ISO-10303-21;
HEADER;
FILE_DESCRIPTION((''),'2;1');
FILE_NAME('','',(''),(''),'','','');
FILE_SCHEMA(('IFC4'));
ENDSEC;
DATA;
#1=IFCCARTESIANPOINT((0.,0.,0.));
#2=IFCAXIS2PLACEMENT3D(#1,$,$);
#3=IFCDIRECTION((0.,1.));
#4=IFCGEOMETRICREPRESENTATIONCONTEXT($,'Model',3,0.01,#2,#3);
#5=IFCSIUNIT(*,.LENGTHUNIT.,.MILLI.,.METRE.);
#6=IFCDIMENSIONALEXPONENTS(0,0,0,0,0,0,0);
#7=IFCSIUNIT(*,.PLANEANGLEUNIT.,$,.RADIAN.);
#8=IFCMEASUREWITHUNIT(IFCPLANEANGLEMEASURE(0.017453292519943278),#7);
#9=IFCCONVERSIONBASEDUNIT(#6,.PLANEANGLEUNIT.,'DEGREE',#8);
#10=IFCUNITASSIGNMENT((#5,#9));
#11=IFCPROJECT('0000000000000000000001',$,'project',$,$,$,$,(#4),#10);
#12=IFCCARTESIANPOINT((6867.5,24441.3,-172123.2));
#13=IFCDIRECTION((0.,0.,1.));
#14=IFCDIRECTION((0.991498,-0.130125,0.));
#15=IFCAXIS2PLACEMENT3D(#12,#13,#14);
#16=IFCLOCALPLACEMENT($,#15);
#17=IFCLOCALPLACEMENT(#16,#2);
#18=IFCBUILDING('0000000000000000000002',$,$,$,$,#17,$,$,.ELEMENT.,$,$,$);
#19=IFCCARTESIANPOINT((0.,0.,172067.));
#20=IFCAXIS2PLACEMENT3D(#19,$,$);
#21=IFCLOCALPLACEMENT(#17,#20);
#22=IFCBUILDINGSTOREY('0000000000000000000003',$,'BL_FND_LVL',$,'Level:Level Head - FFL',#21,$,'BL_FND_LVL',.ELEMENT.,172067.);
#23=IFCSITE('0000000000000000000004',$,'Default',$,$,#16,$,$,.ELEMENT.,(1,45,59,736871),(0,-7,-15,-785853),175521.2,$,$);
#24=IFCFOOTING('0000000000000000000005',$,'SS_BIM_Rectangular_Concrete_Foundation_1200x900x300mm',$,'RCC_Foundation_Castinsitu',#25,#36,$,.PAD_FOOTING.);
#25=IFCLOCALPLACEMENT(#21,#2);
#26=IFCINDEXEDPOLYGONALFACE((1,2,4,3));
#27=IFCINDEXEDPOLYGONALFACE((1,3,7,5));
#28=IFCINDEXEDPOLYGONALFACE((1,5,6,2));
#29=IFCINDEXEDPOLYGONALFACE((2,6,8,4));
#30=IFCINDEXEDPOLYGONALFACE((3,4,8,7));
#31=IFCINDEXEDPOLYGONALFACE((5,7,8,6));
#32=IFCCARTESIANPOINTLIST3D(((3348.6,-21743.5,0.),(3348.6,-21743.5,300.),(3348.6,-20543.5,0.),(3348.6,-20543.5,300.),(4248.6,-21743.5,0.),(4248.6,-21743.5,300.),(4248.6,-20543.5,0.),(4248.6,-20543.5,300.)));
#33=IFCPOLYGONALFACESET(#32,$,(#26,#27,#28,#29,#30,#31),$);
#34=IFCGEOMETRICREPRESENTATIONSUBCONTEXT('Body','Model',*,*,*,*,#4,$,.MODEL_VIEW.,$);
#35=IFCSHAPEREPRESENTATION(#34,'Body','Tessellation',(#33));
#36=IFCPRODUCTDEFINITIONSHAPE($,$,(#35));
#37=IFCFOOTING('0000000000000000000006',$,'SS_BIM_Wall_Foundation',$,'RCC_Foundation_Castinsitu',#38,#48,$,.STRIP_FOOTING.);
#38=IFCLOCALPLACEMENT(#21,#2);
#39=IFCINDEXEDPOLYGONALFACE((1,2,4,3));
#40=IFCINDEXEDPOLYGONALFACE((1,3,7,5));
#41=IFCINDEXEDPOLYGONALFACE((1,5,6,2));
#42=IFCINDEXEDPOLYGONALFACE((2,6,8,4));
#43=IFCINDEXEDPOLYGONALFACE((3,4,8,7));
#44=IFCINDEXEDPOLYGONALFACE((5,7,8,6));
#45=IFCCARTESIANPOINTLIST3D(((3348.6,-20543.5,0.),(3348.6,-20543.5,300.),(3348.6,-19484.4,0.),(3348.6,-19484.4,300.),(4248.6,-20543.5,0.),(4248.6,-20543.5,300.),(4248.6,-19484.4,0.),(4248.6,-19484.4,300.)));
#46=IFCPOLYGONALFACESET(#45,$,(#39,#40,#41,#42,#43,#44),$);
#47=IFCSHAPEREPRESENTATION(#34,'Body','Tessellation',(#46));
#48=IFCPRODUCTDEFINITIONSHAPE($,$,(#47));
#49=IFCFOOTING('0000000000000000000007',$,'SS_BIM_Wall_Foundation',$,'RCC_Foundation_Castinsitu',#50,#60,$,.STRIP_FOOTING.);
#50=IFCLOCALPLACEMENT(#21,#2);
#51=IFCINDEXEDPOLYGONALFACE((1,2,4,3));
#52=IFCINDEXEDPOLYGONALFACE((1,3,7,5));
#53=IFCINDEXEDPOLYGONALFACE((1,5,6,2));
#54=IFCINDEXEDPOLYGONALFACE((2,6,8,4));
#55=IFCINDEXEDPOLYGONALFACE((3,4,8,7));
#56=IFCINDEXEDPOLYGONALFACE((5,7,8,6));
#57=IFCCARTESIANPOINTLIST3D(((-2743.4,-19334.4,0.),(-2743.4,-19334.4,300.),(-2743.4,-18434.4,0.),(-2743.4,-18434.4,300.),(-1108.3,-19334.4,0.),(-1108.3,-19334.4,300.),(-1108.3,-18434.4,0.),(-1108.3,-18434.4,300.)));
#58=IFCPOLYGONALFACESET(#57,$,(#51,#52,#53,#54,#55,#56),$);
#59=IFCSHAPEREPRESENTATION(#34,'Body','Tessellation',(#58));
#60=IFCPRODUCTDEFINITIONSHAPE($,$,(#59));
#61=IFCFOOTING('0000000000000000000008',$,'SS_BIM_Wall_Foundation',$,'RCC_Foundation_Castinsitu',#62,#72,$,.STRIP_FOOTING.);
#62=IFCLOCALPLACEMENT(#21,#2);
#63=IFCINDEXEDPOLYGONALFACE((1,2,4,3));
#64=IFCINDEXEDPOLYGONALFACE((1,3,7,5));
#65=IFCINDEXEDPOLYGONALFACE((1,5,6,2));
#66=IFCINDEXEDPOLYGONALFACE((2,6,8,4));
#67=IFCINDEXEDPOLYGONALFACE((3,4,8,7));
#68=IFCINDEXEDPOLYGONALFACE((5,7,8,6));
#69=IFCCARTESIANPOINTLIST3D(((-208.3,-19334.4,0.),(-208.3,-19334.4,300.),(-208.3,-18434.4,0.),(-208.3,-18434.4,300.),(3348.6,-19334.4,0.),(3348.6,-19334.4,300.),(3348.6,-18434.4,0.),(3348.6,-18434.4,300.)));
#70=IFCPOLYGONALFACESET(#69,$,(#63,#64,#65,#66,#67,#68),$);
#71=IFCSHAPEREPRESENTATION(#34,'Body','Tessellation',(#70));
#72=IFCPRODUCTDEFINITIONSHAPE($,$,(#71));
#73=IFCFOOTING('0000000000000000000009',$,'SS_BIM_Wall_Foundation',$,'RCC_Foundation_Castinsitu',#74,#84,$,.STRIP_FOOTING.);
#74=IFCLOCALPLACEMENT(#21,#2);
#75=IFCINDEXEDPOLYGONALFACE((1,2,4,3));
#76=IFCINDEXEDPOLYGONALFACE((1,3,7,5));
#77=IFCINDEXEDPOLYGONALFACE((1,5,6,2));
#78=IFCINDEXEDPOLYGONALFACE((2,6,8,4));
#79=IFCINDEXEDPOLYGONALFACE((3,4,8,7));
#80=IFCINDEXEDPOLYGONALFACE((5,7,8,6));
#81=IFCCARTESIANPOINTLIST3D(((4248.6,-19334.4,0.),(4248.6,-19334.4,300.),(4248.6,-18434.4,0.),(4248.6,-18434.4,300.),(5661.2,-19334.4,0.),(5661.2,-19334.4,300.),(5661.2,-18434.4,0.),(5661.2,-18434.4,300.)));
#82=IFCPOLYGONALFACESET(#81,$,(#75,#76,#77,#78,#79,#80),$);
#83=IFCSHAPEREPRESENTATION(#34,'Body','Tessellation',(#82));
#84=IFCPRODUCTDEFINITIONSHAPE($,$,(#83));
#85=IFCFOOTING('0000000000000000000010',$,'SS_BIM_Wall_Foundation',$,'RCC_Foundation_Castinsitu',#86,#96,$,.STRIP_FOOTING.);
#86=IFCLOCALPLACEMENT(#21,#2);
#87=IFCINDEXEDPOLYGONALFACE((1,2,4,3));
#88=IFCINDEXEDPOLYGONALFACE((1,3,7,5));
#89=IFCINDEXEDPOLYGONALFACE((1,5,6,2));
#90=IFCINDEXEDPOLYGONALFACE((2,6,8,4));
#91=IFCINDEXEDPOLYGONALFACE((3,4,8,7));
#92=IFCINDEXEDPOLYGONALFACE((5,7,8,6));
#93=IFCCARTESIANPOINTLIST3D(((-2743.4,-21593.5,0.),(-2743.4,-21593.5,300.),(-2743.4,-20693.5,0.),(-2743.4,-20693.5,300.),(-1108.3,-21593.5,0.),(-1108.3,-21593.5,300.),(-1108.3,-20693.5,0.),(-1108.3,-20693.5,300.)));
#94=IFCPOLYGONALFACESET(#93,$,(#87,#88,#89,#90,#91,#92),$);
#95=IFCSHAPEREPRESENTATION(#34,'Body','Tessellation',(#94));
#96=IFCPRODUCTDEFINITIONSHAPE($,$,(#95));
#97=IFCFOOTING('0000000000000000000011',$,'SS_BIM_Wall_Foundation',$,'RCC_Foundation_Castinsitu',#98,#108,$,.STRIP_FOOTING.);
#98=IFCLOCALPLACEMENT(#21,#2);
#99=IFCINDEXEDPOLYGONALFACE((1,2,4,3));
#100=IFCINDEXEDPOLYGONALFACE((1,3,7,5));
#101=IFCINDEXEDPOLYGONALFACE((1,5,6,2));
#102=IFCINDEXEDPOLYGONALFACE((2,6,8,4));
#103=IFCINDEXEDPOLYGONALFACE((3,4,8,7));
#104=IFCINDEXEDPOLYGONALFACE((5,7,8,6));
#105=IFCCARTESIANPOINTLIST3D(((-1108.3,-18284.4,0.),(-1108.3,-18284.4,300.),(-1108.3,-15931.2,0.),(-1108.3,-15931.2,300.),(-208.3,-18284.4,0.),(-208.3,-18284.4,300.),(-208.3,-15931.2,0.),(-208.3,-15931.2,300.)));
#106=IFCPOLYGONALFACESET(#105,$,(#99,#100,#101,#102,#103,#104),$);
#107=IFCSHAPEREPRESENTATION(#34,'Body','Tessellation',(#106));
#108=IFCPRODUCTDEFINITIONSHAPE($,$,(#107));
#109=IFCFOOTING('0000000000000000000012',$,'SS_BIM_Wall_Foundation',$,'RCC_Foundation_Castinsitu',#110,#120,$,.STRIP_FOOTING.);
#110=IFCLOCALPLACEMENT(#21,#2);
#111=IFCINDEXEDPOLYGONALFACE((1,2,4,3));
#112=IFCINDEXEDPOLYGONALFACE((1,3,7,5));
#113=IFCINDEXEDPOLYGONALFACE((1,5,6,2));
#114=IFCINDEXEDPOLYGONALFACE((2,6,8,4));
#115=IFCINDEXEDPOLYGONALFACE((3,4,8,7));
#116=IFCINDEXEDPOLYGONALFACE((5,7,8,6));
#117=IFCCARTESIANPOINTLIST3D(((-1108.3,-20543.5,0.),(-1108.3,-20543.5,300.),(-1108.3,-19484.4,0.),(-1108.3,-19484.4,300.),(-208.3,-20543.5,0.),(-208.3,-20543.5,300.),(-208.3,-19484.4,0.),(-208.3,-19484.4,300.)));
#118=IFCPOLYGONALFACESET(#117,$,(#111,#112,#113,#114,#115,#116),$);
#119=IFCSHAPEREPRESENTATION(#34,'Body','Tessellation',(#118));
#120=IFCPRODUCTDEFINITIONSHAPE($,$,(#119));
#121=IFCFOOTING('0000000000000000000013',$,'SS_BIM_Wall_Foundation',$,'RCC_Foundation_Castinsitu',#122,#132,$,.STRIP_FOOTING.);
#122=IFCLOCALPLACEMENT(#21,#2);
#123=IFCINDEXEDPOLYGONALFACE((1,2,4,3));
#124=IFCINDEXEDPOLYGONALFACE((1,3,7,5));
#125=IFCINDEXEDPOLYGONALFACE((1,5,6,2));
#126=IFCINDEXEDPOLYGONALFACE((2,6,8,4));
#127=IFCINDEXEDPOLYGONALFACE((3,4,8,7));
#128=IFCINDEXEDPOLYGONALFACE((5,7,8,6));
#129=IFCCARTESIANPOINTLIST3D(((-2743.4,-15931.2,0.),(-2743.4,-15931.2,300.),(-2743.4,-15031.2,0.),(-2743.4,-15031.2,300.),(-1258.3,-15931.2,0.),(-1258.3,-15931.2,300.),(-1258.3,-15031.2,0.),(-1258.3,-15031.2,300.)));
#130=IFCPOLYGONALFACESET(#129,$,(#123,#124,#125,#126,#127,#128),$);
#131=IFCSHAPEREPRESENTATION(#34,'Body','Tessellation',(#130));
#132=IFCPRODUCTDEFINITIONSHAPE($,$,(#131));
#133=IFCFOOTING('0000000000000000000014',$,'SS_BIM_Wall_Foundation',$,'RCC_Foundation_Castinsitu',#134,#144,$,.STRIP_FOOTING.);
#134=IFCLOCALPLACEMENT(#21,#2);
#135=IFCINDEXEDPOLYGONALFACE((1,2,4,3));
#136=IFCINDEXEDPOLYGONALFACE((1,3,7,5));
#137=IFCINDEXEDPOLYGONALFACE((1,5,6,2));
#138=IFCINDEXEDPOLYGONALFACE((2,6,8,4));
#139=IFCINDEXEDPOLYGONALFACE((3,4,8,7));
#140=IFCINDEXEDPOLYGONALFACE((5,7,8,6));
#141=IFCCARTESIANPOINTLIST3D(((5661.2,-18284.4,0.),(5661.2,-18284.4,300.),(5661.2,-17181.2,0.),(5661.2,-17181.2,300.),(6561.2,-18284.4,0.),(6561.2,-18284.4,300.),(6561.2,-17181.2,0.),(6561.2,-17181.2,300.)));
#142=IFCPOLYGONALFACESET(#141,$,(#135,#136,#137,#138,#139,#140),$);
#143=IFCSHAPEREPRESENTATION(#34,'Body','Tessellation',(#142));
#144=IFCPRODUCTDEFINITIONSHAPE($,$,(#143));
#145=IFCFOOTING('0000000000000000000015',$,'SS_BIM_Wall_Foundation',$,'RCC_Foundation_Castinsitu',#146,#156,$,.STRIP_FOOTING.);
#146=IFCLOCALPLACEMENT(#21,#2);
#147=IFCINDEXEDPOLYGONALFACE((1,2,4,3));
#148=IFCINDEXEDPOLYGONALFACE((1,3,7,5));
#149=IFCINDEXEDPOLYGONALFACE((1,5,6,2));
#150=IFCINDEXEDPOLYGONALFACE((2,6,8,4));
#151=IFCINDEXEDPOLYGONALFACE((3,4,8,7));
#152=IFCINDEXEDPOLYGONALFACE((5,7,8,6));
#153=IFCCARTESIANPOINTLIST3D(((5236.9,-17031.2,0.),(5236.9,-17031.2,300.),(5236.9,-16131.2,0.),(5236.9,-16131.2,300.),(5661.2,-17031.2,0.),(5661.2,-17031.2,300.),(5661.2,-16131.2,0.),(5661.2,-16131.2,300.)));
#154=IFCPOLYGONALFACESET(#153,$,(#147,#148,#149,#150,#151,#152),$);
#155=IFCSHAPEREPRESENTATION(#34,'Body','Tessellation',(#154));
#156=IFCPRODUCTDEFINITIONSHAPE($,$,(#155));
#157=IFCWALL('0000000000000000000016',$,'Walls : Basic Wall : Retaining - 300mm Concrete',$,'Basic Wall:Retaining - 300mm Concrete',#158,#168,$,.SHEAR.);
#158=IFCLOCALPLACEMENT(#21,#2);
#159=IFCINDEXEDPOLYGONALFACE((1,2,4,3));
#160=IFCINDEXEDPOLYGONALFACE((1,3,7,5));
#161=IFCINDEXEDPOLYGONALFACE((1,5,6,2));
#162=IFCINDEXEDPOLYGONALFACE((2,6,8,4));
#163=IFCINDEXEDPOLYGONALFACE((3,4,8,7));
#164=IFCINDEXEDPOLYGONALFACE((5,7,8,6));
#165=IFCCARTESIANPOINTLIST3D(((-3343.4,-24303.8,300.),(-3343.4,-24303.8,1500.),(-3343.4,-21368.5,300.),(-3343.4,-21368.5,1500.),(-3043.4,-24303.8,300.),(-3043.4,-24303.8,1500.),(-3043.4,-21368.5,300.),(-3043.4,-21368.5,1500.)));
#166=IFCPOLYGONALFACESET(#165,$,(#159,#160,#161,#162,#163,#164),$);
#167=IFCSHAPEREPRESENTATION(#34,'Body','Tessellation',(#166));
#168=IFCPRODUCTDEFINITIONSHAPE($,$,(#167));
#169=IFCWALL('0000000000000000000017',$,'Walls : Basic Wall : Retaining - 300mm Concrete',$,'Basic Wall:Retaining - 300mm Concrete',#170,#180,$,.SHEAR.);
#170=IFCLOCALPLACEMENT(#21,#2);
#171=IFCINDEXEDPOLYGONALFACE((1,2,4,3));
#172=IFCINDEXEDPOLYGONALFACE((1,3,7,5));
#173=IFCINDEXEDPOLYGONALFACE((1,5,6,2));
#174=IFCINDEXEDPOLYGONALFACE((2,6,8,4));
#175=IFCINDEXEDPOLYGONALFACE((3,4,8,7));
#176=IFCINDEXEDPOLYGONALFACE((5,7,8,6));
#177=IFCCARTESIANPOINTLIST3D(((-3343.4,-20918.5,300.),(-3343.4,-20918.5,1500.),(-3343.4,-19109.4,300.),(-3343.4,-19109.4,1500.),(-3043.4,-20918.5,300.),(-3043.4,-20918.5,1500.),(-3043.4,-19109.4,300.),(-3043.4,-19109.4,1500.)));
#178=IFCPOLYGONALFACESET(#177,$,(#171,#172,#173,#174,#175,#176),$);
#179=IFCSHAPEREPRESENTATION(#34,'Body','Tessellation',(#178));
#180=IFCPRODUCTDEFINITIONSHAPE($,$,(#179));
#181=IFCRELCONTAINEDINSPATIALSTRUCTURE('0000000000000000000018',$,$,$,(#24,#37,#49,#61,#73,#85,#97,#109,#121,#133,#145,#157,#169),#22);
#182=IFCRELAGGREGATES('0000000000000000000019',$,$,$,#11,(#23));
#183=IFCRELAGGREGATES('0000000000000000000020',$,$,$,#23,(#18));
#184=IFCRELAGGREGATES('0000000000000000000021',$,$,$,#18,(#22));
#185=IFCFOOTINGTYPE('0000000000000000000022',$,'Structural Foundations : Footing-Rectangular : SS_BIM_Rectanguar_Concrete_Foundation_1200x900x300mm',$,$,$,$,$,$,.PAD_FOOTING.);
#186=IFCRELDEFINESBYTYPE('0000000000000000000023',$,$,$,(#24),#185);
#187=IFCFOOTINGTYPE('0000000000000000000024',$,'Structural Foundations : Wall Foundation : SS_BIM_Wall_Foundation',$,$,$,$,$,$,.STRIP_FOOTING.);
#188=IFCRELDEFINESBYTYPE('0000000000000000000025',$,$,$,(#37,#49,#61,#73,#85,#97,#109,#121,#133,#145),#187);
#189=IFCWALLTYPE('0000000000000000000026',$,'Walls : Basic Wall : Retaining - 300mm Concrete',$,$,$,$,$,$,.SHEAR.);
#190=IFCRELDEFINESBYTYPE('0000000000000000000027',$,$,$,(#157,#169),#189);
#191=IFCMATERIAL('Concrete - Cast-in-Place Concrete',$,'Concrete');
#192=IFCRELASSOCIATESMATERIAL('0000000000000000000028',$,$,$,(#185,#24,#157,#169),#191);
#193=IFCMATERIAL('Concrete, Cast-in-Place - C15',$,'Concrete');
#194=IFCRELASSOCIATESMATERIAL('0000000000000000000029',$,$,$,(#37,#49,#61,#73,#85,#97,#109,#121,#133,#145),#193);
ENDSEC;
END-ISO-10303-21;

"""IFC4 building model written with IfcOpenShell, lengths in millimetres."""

from ifc_helpers import new_model, entity, si_unit, converted_unit, direction, frame, origin, place, context, subcontext, project, spatial, indexed_curve, outline, extrude, source, transform, mapped, material, type_object, type_shapes, element, save


model = new_model("IFC4")

# Units and contexts
model_context = context("Model", 3, precision=0.01, world=origin(), true_north=direction((0.0, 1.0)))
body_context = subcontext(model_context, "Body", "Model", "MODEL_VIEW")
ifc_project = project(units=[si_unit("LENGTHUNIT", "METRE", prefix="MILLI"), converted_unit("PLANEANGLEUNIT", "DEGREE", entity("IfcPlaneAngleMeasure", 0.017453292519943278), si_unit("PLANEANGLEUNIT", "RADIAN"), dimensions=[0, 0, 0, 0, 0, 0, 0])], contexts=[model_context])

# Site, building, storey
site_placement = place(None, frame((6867.5, 24441.3, -172123.2), z_axis=(0.0, 0.0, 1.0), x_axis=(0.991498, -0.130125, 0.0)))
site = spatial("IfcSite", under=ifc_project, at=site_placement, Name="Default", CompositionType="ELEMENT", RefLatitude=(1, 45, 59, 736871), RefLongitude=(0, -7, -15, -785853), RefElevation=175521.2)
building_placement = place(site_placement, origin())
building = spatial("IfcBuilding", under=site, at=building_placement, CompositionType="ELEMENT")
storey_placement = place(building_placement, frame((0.0, 0.0, 172067.0)))
storey = spatial("IfcBuildingStorey", under=building, at=storey_placement, Name="BL_FND_LVL", ObjectType="Level:Level Head - FFL", LongName="BL_FND_LVL", CompositionType="ELEMENT", Elevation=172067.0)

# Footings
ifc_material_1 = material(Name="Concrete - Cast-in-Place Concrete", Category="Concrete")
footing_type_1 = type_object("IfcFootingType", Name="Structural Foundations : Footing-Rectangular : SS_BIM_Rectanguar_Concrete_Foundation_1200x900x300mm", PredefinedType="PAD_FOOTING", material=ifc_material_1)
shared_shape = source(origin(), body_context, "Body", "SweptSolid", [
    extrude(outline(indexed_curve([(-450.0, -600.0), (450.0, -600.0), (450.0, 600.0), (-450.0, 600.0), (-450.0, -600.0)], self_intersect=False)), frame((0.0, 0.0, -300.0), z_axis=(0.0, 0.0, 1.0), x_axis=(-1.0, 0.0, 0.0)), (0.0, 0.0, 1.0), 300.0),
])
type_shapes(footing_type_1, [shared_shape])
footing_1_placement = place(storey_placement, frame((3798.6, -21143.5, 300.0)))
element("IfcFooting", 1, at=footing_1_placement, inside=storey, type_object=footing_type_1, material=ifc_material_1, Name="SS_BIM_Rectangular_Concrete_Foundation_1200x900x300mm", ObjectType="RCC_Foundation_Castinsitu", PredefinedType="PAD_FOOTING", context=body_context, shape_type="MappedRepresentation", body=[
    mapped(shared_shape, transform((0.0, 0.0, 0.0), scale=1.0)),
])
ifc_material_2 = material(Name="Concrete, Cast-in-Place - C15", Category="Concrete")
footing_type_2 = type_object("IfcFootingType", Name="Structural Foundations : Wall Foundation : SS_BIM_Wall_Foundation", PredefinedType="STRIP_FOOTING")
footing_2_placement = place(storey_placement, origin())
element("IfcFooting", 2, at=footing_2_placement, inside=storey, type_object=footing_type_2, material=ifc_material_2, Name="SS_BIM_Wall_Foundation", ObjectType="RCC_Foundation_Castinsitu", PredefinedType="STRIP_FOOTING", context=body_context, shape_type="SweptSolid", body=[
    extrude(outline(indexed_curve([(-529.6, -450.0), (529.6, -450.0), (529.6, 450.0), (-529.6, 450.0), (-529.6, -450.0)], self_intersect=False)), frame((3798.6, -20013.9, 0.0), z_axis=(0.0, 0.0, 1.0), x_axis=(0.0, -1.0, 0.0)), (0.0, 0.0, 1.0), 300.0),
])
footing_3_placement = place(storey_placement, origin())
element("IfcFooting", 3, at=footing_3_placement, inside=storey, type_object=footing_type_2, material=ifc_material_2, Name="SS_BIM_Wall_Foundation", ObjectType="RCC_Foundation_Castinsitu", PredefinedType="STRIP_FOOTING", context=body_context, shape_type="SweptSolid", body=[
    extrude(outline(indexed_curve([(-817.5, -450.0), (817.5, -450.0), (817.5, 450.0), (-817.5, 450.0), (-817.5, -450.0)], self_intersect=False)), frame((-1925.8, -18884.4, 0.0)), (0.0, 0.0, 1.0), 300.0),
])
footing_4_placement = place(storey_placement, origin())
element("IfcFooting", 4, at=footing_4_placement, inside=storey, type_object=footing_type_2, material=ifc_material_2, Name="SS_BIM_Wall_Foundation", ObjectType="RCC_Foundation_Castinsitu", PredefinedType="STRIP_FOOTING", context=body_context, shape_type="SweptSolid", body=[
    extrude(outline(indexed_curve([(-1778.5, -450.0), (1778.5, -450.0), (1778.5, 450.0), (-1778.5, 450.0), (-1778.5, -450.0)], self_intersect=False)), frame((1570.2, -18884.4, 0.0)), (0.0, 0.0, 1.0), 300.0),
])
footing_5_placement = place(storey_placement, origin())
element("IfcFooting", 5, at=footing_5_placement, inside=storey, type_object=footing_type_2, material=ifc_material_2, Name="SS_BIM_Wall_Foundation", ObjectType="RCC_Foundation_Castinsitu", PredefinedType="STRIP_FOOTING", context=body_context, shape_type="SweptSolid", body=[
    extrude(outline(indexed_curve([(-706.3, -450.0), (706.3, -450.0), (706.3, 450.0), (-706.3, 450.0), (-706.3, -450.0)], self_intersect=False)), frame((4954.9, -18884.4, 0.0)), (0.0, 0.0, 1.0), 300.0),
])
footing_6_placement = place(storey_placement, origin())
element("IfcFooting", 6, at=footing_6_placement, inside=storey, type_object=footing_type_2, material=ifc_material_2, Name="SS_BIM_Wall_Foundation", ObjectType="RCC_Foundation_Castinsitu", PredefinedType="STRIP_FOOTING", context=body_context, shape_type="SweptSolid", body=[
    extrude(outline(indexed_curve([(-817.5, -450.0), (817.5, -450.0), (817.5, 450.0), (-817.5, 450.0), (-817.5, -450.0)], self_intersect=False)), frame((-1925.8, -21143.5, 0.0)), (0.0, 0.0, 1.0), 300.0),
])
footing_7_placement = place(storey_placement, origin())
element("IfcFooting", 7, at=footing_7_placement, inside=storey, type_object=footing_type_2, material=ifc_material_2, Name="SS_BIM_Wall_Foundation", ObjectType="RCC_Foundation_Castinsitu", PredefinedType="STRIP_FOOTING", context=body_context, shape_type="SweptSolid", body=[
    extrude(outline(indexed_curve([(-1176.6, -450.0), (1176.6, -450.0), (1176.6, 450.0), (-1176.6, 450.0), (-1176.6, -450.0)], self_intersect=False)), frame((-658.3, -17107.8, 0.0), z_axis=(0.0, 0.0, 1.0), x_axis=(0.0, -1.0, 0.0)), (0.0, 0.0, 1.0), 300.0),
])
footing_8_placement = place(storey_placement, origin())
element("IfcFooting", 8, at=footing_8_placement, inside=storey, type_object=footing_type_2, material=ifc_material_2, Name="SS_BIM_Wall_Foundation", ObjectType="RCC_Foundation_Castinsitu", PredefinedType="STRIP_FOOTING", context=body_context, shape_type="SweptSolid", body=[
    extrude(outline(indexed_curve([(-529.6, -450.0), (529.6, -450.0), (529.6, 450.0), (-529.6, 450.0), (-529.6, -450.0)], self_intersect=False)), frame((-658.3, -20013.9, 0.0), z_axis=(0.0, 0.0, 1.0), x_axis=(0.0, -1.0, 0.0)), (0.0, 0.0, 1.0), 300.0),
])
footing_9_placement = place(storey_placement, origin())
element("IfcFooting", 9, at=footing_9_placement, inside=storey, type_object=footing_type_2, material=ifc_material_2, Name="SS_BIM_Wall_Foundation", ObjectType="RCC_Foundation_Castinsitu", PredefinedType="STRIP_FOOTING", context=body_context, shape_type="SweptSolid", body=[
    extrude(outline(indexed_curve([(-742.5, -450.0), (742.5, -450.0), (742.5, 450.0), (-742.5, 450.0), (-742.5, -450.0)], self_intersect=False)), frame((-2000.8, -15481.2, 0.0)), (0.0, 0.0, 1.0), 300.0),
])
footing_10_placement = place(storey_placement, origin())
element("IfcFooting", 10, at=footing_10_placement, inside=storey, type_object=footing_type_2, material=ifc_material_2, Name="SS_BIM_Wall_Foundation", ObjectType="RCC_Foundation_Castinsitu", PredefinedType="STRIP_FOOTING", context=body_context, shape_type="SweptSolid", body=[
    extrude(outline(indexed_curve([(-551.6, -450.0), (551.6, -450.0), (551.6, 450.0), (-551.6, 450.0), (-551.6, -450.0)], self_intersect=False)), frame((6111.2, -17732.8, 0.0), z_axis=(0.0, 0.0, 1.0), x_axis=(0.0, 1.0, 0.0)), (0.0, 0.0, 1.0), 300.0),
])
footing_11_placement = place(storey_placement, origin())
element("IfcFooting", 11, at=footing_11_placement, inside=storey, type_object=footing_type_2, material=ifc_material_2, Name="SS_BIM_Wall_Foundation", ObjectType="RCC_Foundation_Castinsitu", PredefinedType="STRIP_FOOTING", context=body_context, shape_type="SweptSolid", body=[
    extrude(outline(indexed_curve([(-212.2, -450.0), (212.2, -450.0), (212.2, 450.0), (-212.2, 450.0), (-212.2, -450.0)], self_intersect=False)), frame((5449.1, -16581.2, 0.0), z_axis=(0.0, 0.0, 1.0), x_axis=(-1.0, 0.0, 0.0)), (0.0, 0.0, 1.0), 300.0),
])

# Walls
wall_type = type_object("IfcWallType", Name="Walls : Basic Wall : Retaining - 300mm Concrete", PredefinedType="SHEAR")
wall_1_placement = place(storey_placement, frame((-3193.4, -24303.8, 300.0), z_axis=(0.0, 0.0, 1.0), x_axis=(0.0, 1.0, 0.0)))
element("IfcWall", 12, at=wall_1_placement, inside=storey, type_object=wall_type, material=ifc_material_1, Name="Walls : Basic Wall : Retaining - 300mm Concrete", ObjectType="Basic Wall:Retaining - 300mm Concrete", PredefinedType="SHEAR", context=body_context, shape_type="SweptSolid", body=[
    extrude(outline(indexed_curve([(2935.3, 150.0), (0.0, 150.0), (0.0, -150.0), (2935.3, -150.0), (2935.3, 150.0)], self_intersect=False)), origin(), (0.0, 0.0, 1.0), 1200.0),
])
wall_2_placement = place(storey_placement, frame((-3193.4, -20918.5, 300.0), z_axis=(0.0, 0.0, 1.0), x_axis=(0.0, 1.0, 0.0)))
element("IfcWall", 13, at=wall_2_placement, inside=storey, type_object=wall_type, material=ifc_material_1, Name="Walls : Basic Wall : Retaining - 300mm Concrete", ObjectType="Basic Wall:Retaining - 300mm Concrete", PredefinedType="SHEAR", context=body_context, shape_type="SweptSolid", body=[
    extrude(outline(indexed_curve([(1809.1, 150.0), (0.0, 150.0), (0.0, -150.0), (1809.1, -150.0), (1809.1, 150.0)], self_intersect=False)), origin(), (0.0, 0.0, 1.0), 1200.0),
])

save(model, "model.ifc")
